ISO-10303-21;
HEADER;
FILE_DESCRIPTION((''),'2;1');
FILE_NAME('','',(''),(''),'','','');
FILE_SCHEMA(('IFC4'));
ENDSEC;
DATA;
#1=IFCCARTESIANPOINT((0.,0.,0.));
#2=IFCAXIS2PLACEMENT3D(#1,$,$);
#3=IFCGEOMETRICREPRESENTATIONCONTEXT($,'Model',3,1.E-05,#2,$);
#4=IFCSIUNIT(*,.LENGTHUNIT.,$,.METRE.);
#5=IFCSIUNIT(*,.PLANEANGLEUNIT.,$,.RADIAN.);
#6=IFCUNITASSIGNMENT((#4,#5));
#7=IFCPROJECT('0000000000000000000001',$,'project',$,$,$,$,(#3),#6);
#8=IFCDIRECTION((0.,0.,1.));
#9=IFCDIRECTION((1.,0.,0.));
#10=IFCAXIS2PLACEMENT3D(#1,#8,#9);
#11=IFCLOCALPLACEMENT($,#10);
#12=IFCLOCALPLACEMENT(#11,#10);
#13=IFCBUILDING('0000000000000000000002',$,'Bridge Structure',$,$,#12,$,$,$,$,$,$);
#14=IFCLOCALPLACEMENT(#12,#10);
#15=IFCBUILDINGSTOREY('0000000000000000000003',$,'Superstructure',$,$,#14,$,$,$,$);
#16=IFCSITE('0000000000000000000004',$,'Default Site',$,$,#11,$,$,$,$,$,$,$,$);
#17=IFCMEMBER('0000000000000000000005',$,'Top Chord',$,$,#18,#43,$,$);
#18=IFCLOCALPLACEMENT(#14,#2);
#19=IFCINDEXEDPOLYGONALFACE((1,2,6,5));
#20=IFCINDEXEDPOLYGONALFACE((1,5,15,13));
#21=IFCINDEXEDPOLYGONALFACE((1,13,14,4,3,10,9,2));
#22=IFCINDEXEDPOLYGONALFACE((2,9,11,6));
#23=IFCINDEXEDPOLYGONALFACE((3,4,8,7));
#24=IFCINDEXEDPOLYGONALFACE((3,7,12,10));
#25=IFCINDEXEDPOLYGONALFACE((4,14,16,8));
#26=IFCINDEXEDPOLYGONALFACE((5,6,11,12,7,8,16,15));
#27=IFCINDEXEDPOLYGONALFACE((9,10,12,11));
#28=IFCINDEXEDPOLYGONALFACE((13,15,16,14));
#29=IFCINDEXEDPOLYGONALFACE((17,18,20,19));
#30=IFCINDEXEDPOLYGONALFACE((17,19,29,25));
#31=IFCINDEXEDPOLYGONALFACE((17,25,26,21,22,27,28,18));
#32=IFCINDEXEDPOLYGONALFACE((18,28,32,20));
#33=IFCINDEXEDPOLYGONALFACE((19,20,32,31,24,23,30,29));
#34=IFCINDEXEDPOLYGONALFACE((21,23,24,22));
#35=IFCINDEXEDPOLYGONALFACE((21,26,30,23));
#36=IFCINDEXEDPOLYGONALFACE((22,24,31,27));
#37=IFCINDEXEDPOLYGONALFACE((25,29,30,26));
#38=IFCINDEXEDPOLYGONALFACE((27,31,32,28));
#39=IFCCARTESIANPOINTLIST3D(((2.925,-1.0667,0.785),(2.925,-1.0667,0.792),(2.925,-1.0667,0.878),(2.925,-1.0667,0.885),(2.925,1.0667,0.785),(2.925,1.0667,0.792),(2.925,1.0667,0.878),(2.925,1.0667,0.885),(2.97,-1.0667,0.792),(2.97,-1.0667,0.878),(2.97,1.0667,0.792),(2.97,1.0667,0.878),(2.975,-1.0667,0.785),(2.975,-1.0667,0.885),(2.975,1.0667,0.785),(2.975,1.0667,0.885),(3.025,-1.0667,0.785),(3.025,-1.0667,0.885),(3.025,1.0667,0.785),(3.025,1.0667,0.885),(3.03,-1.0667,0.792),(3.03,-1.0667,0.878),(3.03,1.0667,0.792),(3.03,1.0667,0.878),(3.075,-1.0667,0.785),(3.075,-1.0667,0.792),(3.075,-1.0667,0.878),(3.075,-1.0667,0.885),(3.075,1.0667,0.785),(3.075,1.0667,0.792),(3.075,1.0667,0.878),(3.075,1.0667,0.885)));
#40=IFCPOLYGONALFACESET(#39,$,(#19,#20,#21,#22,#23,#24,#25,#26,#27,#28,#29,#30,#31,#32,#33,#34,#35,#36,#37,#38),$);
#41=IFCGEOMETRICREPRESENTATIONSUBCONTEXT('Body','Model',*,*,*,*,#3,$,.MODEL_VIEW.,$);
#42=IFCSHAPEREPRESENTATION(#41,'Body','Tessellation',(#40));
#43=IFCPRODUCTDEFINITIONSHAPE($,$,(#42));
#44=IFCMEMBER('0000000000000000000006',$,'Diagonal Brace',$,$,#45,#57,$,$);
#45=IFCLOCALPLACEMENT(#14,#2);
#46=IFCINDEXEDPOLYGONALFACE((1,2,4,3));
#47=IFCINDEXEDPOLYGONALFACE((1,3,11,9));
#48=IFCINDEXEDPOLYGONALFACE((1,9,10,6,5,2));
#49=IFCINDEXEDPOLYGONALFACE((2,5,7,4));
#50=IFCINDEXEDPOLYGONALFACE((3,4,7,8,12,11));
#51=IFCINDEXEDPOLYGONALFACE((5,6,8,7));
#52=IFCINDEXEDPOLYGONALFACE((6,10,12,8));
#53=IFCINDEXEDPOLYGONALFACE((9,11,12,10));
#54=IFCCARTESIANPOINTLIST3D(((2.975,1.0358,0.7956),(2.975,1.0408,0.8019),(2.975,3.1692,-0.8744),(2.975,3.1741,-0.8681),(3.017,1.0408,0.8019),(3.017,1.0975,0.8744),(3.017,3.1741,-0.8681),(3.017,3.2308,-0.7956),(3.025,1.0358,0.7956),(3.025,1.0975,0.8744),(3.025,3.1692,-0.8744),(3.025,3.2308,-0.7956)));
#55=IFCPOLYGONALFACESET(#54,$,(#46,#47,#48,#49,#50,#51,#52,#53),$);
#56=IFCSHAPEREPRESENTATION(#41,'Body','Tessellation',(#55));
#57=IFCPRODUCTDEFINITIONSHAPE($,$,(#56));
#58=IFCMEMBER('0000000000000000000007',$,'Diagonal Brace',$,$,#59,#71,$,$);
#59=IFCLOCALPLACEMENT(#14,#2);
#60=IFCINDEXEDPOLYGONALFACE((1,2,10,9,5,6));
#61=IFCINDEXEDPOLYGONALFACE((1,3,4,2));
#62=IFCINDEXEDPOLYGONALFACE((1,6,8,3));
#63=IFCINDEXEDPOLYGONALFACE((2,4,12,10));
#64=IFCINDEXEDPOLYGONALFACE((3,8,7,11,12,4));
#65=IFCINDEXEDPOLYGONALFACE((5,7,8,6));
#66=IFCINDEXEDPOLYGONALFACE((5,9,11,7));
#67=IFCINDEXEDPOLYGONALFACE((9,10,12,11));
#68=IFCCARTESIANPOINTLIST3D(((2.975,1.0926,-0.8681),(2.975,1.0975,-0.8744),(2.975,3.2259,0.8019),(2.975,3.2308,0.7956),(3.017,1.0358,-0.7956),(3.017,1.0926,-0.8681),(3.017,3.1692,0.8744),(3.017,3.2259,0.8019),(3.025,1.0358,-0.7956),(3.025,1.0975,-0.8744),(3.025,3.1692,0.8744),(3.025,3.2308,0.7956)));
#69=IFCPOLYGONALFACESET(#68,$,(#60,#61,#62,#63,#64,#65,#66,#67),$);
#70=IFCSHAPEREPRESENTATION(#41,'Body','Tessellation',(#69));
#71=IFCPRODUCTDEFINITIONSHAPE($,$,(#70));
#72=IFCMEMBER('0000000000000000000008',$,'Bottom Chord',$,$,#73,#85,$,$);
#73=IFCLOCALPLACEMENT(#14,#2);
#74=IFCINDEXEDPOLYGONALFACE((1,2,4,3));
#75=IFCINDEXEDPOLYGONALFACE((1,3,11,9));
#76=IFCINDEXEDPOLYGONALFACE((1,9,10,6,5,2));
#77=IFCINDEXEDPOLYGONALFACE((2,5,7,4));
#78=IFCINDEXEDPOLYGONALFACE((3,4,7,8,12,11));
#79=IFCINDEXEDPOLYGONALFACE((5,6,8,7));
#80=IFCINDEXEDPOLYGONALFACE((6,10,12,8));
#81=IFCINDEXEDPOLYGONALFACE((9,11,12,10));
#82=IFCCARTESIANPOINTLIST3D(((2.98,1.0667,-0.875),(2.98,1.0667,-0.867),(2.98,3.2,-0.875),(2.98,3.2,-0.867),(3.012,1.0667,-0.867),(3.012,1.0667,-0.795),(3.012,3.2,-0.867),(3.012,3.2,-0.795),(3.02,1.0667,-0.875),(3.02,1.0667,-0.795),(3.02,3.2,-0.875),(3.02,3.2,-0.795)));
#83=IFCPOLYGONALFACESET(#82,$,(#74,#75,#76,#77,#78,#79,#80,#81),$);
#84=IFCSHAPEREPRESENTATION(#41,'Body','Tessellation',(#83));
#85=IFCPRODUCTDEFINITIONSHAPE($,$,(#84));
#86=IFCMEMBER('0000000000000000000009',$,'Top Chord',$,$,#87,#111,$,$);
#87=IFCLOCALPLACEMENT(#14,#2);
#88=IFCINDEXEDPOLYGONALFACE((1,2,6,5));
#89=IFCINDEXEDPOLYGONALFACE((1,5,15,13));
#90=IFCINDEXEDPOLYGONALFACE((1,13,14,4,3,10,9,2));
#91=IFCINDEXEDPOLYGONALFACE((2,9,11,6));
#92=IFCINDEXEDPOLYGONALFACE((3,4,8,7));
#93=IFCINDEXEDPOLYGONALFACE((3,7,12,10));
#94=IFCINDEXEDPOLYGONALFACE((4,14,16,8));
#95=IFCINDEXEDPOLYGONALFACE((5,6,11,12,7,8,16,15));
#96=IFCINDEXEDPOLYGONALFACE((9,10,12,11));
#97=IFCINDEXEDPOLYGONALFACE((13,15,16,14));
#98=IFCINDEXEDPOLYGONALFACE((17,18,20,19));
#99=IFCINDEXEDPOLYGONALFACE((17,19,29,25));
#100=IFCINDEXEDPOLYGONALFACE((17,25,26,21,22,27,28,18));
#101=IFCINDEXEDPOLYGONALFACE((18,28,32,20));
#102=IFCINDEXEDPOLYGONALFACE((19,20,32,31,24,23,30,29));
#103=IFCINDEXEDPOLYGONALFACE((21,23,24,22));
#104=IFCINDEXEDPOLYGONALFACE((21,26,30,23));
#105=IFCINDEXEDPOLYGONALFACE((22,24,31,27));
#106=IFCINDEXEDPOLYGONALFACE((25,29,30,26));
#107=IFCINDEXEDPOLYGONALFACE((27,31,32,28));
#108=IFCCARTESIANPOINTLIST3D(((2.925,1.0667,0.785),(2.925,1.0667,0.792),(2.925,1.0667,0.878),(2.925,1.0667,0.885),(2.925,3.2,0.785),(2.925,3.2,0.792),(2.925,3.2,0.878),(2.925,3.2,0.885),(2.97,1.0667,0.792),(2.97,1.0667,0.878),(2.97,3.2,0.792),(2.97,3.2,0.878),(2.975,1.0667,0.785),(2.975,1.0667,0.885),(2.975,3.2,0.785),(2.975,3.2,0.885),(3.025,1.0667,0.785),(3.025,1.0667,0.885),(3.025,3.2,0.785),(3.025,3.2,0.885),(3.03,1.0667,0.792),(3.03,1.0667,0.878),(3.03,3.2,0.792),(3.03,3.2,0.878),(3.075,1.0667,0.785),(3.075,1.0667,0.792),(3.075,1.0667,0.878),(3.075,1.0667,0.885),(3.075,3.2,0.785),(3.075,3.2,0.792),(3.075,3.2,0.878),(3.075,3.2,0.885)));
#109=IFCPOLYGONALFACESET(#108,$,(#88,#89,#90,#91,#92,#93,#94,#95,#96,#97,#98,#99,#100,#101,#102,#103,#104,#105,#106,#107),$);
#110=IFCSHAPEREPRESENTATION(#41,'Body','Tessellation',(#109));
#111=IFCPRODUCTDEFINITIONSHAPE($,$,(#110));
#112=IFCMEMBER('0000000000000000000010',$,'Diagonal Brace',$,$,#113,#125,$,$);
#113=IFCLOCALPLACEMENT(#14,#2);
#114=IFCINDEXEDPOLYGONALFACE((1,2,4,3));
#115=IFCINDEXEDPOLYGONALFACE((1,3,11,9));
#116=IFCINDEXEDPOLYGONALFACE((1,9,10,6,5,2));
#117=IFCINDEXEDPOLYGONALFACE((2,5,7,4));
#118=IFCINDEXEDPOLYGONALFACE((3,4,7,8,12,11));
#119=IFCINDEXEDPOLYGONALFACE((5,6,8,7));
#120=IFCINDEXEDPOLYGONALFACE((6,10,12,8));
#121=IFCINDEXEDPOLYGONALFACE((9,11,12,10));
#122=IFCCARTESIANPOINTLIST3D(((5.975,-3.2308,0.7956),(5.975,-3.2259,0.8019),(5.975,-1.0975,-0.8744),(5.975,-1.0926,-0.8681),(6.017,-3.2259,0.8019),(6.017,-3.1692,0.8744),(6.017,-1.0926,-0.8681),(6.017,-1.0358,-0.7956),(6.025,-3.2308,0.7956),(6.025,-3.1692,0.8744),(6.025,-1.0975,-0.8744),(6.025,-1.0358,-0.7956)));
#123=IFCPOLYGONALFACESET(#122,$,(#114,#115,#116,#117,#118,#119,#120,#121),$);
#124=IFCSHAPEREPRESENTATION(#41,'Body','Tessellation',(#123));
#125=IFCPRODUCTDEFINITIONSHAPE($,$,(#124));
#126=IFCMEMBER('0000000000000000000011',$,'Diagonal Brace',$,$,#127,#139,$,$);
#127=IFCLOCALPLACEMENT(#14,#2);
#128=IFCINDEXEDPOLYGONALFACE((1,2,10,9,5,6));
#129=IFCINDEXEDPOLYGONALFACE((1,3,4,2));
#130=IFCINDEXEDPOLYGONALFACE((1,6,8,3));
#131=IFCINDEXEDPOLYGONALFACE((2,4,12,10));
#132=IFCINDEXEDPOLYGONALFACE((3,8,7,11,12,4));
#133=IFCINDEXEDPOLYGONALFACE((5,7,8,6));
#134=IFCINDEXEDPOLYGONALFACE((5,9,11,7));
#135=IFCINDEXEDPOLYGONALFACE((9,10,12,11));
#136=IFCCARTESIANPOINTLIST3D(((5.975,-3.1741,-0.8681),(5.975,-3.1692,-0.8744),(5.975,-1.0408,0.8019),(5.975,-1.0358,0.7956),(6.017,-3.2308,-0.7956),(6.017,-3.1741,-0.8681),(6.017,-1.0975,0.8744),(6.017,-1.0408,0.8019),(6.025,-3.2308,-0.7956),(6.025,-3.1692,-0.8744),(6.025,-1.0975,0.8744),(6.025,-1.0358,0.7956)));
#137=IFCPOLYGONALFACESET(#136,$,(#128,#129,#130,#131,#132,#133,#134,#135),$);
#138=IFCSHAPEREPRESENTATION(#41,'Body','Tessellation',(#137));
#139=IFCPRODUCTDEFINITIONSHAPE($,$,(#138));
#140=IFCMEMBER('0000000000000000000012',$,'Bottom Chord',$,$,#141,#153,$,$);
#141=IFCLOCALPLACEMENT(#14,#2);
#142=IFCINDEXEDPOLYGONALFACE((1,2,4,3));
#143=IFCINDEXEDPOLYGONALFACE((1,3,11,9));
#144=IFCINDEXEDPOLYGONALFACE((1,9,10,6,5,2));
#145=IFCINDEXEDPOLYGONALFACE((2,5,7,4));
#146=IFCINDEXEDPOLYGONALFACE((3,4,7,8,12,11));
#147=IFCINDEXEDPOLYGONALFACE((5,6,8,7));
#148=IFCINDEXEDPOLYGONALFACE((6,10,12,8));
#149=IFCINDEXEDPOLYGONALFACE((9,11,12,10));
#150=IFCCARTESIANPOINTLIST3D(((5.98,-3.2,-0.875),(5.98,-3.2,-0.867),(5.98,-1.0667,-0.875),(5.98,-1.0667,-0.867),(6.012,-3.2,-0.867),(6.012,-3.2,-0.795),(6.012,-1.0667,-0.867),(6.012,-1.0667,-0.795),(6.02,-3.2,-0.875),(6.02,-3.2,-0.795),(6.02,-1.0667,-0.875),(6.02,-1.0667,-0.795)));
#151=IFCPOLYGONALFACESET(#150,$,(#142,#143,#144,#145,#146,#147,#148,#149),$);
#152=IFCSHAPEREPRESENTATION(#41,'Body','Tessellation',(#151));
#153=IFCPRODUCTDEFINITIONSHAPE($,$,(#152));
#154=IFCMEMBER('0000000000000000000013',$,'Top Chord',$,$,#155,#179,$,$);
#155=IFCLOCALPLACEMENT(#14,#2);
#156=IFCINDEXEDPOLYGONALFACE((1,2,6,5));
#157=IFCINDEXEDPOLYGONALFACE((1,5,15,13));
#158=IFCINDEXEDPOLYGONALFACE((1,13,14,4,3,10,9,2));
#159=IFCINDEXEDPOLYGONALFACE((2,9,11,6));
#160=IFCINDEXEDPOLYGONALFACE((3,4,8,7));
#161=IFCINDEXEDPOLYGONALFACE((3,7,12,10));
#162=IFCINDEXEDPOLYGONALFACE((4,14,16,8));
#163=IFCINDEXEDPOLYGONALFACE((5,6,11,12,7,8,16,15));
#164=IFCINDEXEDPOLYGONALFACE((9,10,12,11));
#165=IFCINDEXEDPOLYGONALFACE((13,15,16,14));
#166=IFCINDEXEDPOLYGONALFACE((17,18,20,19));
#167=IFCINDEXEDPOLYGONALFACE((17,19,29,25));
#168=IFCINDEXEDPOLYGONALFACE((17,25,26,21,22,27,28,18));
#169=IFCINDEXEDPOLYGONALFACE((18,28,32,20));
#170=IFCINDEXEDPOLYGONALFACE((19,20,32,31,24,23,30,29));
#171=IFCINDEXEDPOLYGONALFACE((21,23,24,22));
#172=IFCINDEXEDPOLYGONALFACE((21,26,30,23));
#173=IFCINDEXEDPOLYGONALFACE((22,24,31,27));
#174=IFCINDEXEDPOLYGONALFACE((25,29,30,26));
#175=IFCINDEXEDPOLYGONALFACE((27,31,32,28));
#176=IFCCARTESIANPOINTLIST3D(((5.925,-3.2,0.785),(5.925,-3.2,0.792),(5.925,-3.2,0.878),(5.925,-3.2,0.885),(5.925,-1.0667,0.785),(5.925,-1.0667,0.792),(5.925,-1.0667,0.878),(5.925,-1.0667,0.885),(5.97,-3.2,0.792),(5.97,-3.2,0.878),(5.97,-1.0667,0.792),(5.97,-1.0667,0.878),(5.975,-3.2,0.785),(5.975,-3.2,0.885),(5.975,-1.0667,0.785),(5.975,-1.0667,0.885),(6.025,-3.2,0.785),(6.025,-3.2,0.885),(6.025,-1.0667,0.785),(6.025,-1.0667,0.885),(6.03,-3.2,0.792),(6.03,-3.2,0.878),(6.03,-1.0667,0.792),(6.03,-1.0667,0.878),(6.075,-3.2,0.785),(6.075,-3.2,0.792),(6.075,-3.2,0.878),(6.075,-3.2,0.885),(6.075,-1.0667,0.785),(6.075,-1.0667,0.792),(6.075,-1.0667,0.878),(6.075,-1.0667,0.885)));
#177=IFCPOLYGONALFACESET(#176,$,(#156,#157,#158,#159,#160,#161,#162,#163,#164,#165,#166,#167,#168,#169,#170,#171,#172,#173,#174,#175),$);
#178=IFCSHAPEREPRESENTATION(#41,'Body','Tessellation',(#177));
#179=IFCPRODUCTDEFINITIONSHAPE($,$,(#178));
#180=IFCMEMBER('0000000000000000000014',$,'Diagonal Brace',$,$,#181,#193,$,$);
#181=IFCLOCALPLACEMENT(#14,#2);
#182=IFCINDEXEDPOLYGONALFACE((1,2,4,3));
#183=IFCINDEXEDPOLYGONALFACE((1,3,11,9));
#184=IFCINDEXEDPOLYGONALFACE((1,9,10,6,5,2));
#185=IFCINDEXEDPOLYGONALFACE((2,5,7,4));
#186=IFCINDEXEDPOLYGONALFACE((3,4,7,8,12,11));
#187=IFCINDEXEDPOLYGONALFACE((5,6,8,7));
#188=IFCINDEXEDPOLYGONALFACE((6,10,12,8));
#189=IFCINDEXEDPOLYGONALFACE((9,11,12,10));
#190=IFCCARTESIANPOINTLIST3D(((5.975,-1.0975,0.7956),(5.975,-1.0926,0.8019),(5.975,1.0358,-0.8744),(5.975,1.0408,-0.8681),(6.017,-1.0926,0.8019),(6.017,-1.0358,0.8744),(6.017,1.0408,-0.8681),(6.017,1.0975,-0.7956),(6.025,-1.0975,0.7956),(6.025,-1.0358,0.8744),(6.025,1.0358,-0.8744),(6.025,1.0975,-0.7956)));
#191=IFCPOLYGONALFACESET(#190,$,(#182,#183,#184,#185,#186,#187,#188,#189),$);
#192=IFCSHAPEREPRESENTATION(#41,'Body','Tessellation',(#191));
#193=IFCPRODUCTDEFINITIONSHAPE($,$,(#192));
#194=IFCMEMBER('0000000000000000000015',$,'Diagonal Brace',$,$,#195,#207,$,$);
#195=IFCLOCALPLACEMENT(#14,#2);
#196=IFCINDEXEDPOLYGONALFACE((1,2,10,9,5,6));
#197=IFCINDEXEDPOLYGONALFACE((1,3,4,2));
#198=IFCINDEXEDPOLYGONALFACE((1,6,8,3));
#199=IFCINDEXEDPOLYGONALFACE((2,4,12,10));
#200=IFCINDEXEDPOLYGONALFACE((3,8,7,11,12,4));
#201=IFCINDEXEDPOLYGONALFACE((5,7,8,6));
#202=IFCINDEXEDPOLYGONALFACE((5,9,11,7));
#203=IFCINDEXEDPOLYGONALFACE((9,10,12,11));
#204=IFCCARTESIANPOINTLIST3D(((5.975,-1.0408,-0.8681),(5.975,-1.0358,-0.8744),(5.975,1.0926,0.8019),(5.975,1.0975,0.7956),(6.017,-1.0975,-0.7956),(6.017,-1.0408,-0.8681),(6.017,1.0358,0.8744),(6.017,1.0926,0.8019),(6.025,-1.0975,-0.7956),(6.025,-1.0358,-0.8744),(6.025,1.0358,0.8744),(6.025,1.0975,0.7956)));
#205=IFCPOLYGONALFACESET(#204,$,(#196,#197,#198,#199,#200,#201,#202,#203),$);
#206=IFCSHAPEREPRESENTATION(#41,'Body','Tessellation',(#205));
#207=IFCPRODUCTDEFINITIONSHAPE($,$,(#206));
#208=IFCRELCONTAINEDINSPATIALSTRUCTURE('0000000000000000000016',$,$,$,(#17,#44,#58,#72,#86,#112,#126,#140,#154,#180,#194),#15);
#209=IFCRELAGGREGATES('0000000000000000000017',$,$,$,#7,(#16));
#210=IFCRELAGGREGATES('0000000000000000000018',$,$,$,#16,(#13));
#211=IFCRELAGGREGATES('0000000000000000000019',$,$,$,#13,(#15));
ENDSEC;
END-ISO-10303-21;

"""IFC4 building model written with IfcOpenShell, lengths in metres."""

from ifc_helpers import new_model, si_unit, frame, origin, origin_with_axes, origin_2d_with_axis, place, context, subcontext, project, spatial, polyline, l_section, outline, composite_profile, extrude, element, save


model = new_model("IFC4")

# Units and contexts
model_context = context("Model", 3, precision=1e-05, world=origin())
body_context = subcontext(model_context, "Body", "Model", "MODEL_VIEW")
ifc_project = project(units=[si_unit("LENGTHUNIT", "METRE"), si_unit("PLANEANGLEUNIT", "RADIAN")], contexts=[model_context])

# Site, building, storey
site_placement = place(None, origin_with_axes())
site = spatial("IfcSite", under=ifc_project, at=site_placement, Name="Default Site")
building_placement = place(site_placement, origin_with_axes())
building = spatial("IfcBuilding", under=site, at=building_placement, Name="Bridge Structure")
storey_placement = place(building_placement, origin_with_axes())
storey = spatial("IfcBuildingStorey", under=building, at=storey_placement, Name="Superstructure")

# Members
member_1_placement = place(storey_placement, frame((3.0, -1.0667, 0.835), z_axis=(0.0, 1.0, 0.0), x_axis=(-1.0, 0.0, 0.0)))
element("IfcMember", 1, at=member_1_placement, inside=storey, Name="Top Chord", context=body_context, shape_type="SweptSolid", body=[
    extrude(composite_profile([outline(polyline([(-0.025, -0.05), (-0.025, 0.05), (-0.075, 0.05), (-0.075, 0.043), (-0.03, 0.043), (-0.03, -0.043), (-0.075, -0.043), (-0.075, -0.05), (-0.025, -0.05)])), outline(polyline([(0.025, -0.05), (0.075, -0.05), (0.075, -0.043), (0.03, -0.043), (0.03, 0.043), (0.075, 0.043), (0.075, 0.05), (0.025, 0.05), (0.025, -0.05)]))]), origin_with_axes(), (0.0, 0.0, 1.0), 2.1333),
])
for number, where, z_axis, x_axis, name in (
    (2, (3.0, 1.0667, 0.835), (0.0, 0.787427, -0.616408), (-1.0, 0.0, 0.0), "Diagonal Brace"),
    (3, (3.0, 1.0667, -0.835), (0.0, 0.787427, 0.616408), (-1.0, 0.0, 0.0), "Diagonal Brace"),
):
    element("IfcMember", number, at=place(storey_placement, frame(where, z_axis=z_axis, x_axis=x_axis)), inside=storey, Name=name, context=body_context, shape_type="SweptSolid", body=[
        extrude(l_section(Depth=0.1, Width=0.05, Thickness=0.008, at=origin_2d_with_axis()), origin_with_axes(), (0.0, 0.0, 1.0), 2.7092),
    ])
member_2_placement = place(storey_placement, frame((3.0, 1.0667, -0.835), z_axis=(0.0, 1.0, 0.0), x_axis=(-1.0, 0.0, 0.0)))
element("IfcMember", 4, at=member_2_placement, inside=storey, Name="Bottom Chord", context=body_context, shape_type="SweptSolid", body=[
    extrude(l_section(Depth=0.08, Width=0.04, Thickness=0.008, at=origin_2d_with_axis()), origin_with_axes(), (0.0, 0.0, 1.0), 2.1333),
])
member_3_placement = place(storey_placement, frame((3.0, 1.0667, 0.835), z_axis=(0.0, 1.0, 0.0), x_axis=(-1.0, 0.0, 0.0)))
element("IfcMember", 5, at=member_3_placement, inside=storey, Name="Top Chord", context=body_context, shape_type="SweptSolid", body=[
    extrude(composite_profile([outline(polyline([(-0.025, -0.05), (-0.025, 0.05), (-0.075, 0.05), (-0.075, 0.043), (-0.03, 0.043), (-0.03, -0.043), (-0.075, -0.043), (-0.075, -0.05), (-0.025, -0.05)])), outline(polyline([(0.025, -0.05), (0.075, -0.05), (0.075, -0.043), (0.03, -0.043), (0.03, 0.043), (0.075, 0.043), (0.075, 0.05), (0.025, 0.05), (0.025, -0.05)]))]), origin_with_axes(), (0.0, 0.0, 1.0), 2.1333),
])
for number, where, z_axis, x_axis, name in (
    (6, (6.0, -3.2, 0.835), (0.0, 0.787427, -0.616408), (-1.0, 0.0, 0.0), "Diagonal Brace"),
    (7, (6.0, -3.2, -0.835), (0.0, 0.787427, 0.616408), (-1.0, 0.0, 0.0), "Diagonal Brace"),
):
    element("IfcMember", number, at=place(storey_placement, frame(where, z_axis=z_axis, x_axis=x_axis)), inside=storey, Name=name, context=body_context, shape_type="SweptSolid", body=[
        extrude(l_section(Depth=0.1, Width=0.05, Thickness=0.008, at=origin_2d_with_axis()), origin_with_axes(), (0.0, 0.0, 1.0), 2.7092),
    ])
member_4_placement = place(storey_placement, frame((6.0, -3.2, -0.835), z_axis=(0.0, 1.0, 0.0), x_axis=(-1.0, 0.0, 0.0)))
element("IfcMember", 8, at=member_4_placement, inside=storey, Name="Bottom Chord", context=body_context, shape_type="SweptSolid", body=[
    extrude(l_section(Depth=0.08, Width=0.04, Thickness=0.008, at=origin_2d_with_axis()), origin_with_axes(), (0.0, 0.0, 1.0), 2.1333),
])
member_5_placement = place(storey_placement, frame((6.0, -3.2, 0.835), z_axis=(0.0, 1.0, 0.0), x_axis=(-1.0, 0.0, 0.0)))
element("IfcMember", 9, at=member_5_placement, inside=storey, Name="Top Chord", context=body_context, shape_type="SweptSolid", body=[
    extrude(composite_profile([outline(polyline([(-0.025, -0.05), (-0.025, 0.05), (-0.075, 0.05), (-0.075, 0.043), (-0.03, 0.043), (-0.03, -0.043), (-0.075, -0.043), (-0.075, -0.05), (-0.025, -0.05)])), outline(polyline([(0.025, -0.05), (0.075, -0.05), (0.075, -0.043), (0.03, -0.043), (0.03, 0.043), (0.075, 0.043), (0.075, 0.05), (0.025, 0.05), (0.025, -0.05)]))]), origin_with_axes(), (0.0, 0.0, 1.0), 2.1333),
])
for number, where, z_axis, x_axis, name in (
    (10, (6.0, -1.0667, 0.835), (0.0, 0.787427, -0.616408), (-1.0, 0.0, 0.0), "Diagonal Brace"),
    (11, (6.0, -1.0667, -0.835), (0.0, 0.787427, 0.616408), (-1.0, 0.0, 0.0), "Diagonal Brace"),
):
    element("IfcMember", number, at=place(storey_placement, frame(where, z_axis=z_axis, x_axis=x_axis)), inside=storey, Name=name, context=body_context, shape_type="SweptSolid", body=[
        extrude(l_section(Depth=0.1, Width=0.05, Thickness=0.008, at=origin_2d_with_axis()), origin_with_axes(), (0.0, 0.0, 1.0), 2.7092),
    ])

save(model, "model.ifc")
